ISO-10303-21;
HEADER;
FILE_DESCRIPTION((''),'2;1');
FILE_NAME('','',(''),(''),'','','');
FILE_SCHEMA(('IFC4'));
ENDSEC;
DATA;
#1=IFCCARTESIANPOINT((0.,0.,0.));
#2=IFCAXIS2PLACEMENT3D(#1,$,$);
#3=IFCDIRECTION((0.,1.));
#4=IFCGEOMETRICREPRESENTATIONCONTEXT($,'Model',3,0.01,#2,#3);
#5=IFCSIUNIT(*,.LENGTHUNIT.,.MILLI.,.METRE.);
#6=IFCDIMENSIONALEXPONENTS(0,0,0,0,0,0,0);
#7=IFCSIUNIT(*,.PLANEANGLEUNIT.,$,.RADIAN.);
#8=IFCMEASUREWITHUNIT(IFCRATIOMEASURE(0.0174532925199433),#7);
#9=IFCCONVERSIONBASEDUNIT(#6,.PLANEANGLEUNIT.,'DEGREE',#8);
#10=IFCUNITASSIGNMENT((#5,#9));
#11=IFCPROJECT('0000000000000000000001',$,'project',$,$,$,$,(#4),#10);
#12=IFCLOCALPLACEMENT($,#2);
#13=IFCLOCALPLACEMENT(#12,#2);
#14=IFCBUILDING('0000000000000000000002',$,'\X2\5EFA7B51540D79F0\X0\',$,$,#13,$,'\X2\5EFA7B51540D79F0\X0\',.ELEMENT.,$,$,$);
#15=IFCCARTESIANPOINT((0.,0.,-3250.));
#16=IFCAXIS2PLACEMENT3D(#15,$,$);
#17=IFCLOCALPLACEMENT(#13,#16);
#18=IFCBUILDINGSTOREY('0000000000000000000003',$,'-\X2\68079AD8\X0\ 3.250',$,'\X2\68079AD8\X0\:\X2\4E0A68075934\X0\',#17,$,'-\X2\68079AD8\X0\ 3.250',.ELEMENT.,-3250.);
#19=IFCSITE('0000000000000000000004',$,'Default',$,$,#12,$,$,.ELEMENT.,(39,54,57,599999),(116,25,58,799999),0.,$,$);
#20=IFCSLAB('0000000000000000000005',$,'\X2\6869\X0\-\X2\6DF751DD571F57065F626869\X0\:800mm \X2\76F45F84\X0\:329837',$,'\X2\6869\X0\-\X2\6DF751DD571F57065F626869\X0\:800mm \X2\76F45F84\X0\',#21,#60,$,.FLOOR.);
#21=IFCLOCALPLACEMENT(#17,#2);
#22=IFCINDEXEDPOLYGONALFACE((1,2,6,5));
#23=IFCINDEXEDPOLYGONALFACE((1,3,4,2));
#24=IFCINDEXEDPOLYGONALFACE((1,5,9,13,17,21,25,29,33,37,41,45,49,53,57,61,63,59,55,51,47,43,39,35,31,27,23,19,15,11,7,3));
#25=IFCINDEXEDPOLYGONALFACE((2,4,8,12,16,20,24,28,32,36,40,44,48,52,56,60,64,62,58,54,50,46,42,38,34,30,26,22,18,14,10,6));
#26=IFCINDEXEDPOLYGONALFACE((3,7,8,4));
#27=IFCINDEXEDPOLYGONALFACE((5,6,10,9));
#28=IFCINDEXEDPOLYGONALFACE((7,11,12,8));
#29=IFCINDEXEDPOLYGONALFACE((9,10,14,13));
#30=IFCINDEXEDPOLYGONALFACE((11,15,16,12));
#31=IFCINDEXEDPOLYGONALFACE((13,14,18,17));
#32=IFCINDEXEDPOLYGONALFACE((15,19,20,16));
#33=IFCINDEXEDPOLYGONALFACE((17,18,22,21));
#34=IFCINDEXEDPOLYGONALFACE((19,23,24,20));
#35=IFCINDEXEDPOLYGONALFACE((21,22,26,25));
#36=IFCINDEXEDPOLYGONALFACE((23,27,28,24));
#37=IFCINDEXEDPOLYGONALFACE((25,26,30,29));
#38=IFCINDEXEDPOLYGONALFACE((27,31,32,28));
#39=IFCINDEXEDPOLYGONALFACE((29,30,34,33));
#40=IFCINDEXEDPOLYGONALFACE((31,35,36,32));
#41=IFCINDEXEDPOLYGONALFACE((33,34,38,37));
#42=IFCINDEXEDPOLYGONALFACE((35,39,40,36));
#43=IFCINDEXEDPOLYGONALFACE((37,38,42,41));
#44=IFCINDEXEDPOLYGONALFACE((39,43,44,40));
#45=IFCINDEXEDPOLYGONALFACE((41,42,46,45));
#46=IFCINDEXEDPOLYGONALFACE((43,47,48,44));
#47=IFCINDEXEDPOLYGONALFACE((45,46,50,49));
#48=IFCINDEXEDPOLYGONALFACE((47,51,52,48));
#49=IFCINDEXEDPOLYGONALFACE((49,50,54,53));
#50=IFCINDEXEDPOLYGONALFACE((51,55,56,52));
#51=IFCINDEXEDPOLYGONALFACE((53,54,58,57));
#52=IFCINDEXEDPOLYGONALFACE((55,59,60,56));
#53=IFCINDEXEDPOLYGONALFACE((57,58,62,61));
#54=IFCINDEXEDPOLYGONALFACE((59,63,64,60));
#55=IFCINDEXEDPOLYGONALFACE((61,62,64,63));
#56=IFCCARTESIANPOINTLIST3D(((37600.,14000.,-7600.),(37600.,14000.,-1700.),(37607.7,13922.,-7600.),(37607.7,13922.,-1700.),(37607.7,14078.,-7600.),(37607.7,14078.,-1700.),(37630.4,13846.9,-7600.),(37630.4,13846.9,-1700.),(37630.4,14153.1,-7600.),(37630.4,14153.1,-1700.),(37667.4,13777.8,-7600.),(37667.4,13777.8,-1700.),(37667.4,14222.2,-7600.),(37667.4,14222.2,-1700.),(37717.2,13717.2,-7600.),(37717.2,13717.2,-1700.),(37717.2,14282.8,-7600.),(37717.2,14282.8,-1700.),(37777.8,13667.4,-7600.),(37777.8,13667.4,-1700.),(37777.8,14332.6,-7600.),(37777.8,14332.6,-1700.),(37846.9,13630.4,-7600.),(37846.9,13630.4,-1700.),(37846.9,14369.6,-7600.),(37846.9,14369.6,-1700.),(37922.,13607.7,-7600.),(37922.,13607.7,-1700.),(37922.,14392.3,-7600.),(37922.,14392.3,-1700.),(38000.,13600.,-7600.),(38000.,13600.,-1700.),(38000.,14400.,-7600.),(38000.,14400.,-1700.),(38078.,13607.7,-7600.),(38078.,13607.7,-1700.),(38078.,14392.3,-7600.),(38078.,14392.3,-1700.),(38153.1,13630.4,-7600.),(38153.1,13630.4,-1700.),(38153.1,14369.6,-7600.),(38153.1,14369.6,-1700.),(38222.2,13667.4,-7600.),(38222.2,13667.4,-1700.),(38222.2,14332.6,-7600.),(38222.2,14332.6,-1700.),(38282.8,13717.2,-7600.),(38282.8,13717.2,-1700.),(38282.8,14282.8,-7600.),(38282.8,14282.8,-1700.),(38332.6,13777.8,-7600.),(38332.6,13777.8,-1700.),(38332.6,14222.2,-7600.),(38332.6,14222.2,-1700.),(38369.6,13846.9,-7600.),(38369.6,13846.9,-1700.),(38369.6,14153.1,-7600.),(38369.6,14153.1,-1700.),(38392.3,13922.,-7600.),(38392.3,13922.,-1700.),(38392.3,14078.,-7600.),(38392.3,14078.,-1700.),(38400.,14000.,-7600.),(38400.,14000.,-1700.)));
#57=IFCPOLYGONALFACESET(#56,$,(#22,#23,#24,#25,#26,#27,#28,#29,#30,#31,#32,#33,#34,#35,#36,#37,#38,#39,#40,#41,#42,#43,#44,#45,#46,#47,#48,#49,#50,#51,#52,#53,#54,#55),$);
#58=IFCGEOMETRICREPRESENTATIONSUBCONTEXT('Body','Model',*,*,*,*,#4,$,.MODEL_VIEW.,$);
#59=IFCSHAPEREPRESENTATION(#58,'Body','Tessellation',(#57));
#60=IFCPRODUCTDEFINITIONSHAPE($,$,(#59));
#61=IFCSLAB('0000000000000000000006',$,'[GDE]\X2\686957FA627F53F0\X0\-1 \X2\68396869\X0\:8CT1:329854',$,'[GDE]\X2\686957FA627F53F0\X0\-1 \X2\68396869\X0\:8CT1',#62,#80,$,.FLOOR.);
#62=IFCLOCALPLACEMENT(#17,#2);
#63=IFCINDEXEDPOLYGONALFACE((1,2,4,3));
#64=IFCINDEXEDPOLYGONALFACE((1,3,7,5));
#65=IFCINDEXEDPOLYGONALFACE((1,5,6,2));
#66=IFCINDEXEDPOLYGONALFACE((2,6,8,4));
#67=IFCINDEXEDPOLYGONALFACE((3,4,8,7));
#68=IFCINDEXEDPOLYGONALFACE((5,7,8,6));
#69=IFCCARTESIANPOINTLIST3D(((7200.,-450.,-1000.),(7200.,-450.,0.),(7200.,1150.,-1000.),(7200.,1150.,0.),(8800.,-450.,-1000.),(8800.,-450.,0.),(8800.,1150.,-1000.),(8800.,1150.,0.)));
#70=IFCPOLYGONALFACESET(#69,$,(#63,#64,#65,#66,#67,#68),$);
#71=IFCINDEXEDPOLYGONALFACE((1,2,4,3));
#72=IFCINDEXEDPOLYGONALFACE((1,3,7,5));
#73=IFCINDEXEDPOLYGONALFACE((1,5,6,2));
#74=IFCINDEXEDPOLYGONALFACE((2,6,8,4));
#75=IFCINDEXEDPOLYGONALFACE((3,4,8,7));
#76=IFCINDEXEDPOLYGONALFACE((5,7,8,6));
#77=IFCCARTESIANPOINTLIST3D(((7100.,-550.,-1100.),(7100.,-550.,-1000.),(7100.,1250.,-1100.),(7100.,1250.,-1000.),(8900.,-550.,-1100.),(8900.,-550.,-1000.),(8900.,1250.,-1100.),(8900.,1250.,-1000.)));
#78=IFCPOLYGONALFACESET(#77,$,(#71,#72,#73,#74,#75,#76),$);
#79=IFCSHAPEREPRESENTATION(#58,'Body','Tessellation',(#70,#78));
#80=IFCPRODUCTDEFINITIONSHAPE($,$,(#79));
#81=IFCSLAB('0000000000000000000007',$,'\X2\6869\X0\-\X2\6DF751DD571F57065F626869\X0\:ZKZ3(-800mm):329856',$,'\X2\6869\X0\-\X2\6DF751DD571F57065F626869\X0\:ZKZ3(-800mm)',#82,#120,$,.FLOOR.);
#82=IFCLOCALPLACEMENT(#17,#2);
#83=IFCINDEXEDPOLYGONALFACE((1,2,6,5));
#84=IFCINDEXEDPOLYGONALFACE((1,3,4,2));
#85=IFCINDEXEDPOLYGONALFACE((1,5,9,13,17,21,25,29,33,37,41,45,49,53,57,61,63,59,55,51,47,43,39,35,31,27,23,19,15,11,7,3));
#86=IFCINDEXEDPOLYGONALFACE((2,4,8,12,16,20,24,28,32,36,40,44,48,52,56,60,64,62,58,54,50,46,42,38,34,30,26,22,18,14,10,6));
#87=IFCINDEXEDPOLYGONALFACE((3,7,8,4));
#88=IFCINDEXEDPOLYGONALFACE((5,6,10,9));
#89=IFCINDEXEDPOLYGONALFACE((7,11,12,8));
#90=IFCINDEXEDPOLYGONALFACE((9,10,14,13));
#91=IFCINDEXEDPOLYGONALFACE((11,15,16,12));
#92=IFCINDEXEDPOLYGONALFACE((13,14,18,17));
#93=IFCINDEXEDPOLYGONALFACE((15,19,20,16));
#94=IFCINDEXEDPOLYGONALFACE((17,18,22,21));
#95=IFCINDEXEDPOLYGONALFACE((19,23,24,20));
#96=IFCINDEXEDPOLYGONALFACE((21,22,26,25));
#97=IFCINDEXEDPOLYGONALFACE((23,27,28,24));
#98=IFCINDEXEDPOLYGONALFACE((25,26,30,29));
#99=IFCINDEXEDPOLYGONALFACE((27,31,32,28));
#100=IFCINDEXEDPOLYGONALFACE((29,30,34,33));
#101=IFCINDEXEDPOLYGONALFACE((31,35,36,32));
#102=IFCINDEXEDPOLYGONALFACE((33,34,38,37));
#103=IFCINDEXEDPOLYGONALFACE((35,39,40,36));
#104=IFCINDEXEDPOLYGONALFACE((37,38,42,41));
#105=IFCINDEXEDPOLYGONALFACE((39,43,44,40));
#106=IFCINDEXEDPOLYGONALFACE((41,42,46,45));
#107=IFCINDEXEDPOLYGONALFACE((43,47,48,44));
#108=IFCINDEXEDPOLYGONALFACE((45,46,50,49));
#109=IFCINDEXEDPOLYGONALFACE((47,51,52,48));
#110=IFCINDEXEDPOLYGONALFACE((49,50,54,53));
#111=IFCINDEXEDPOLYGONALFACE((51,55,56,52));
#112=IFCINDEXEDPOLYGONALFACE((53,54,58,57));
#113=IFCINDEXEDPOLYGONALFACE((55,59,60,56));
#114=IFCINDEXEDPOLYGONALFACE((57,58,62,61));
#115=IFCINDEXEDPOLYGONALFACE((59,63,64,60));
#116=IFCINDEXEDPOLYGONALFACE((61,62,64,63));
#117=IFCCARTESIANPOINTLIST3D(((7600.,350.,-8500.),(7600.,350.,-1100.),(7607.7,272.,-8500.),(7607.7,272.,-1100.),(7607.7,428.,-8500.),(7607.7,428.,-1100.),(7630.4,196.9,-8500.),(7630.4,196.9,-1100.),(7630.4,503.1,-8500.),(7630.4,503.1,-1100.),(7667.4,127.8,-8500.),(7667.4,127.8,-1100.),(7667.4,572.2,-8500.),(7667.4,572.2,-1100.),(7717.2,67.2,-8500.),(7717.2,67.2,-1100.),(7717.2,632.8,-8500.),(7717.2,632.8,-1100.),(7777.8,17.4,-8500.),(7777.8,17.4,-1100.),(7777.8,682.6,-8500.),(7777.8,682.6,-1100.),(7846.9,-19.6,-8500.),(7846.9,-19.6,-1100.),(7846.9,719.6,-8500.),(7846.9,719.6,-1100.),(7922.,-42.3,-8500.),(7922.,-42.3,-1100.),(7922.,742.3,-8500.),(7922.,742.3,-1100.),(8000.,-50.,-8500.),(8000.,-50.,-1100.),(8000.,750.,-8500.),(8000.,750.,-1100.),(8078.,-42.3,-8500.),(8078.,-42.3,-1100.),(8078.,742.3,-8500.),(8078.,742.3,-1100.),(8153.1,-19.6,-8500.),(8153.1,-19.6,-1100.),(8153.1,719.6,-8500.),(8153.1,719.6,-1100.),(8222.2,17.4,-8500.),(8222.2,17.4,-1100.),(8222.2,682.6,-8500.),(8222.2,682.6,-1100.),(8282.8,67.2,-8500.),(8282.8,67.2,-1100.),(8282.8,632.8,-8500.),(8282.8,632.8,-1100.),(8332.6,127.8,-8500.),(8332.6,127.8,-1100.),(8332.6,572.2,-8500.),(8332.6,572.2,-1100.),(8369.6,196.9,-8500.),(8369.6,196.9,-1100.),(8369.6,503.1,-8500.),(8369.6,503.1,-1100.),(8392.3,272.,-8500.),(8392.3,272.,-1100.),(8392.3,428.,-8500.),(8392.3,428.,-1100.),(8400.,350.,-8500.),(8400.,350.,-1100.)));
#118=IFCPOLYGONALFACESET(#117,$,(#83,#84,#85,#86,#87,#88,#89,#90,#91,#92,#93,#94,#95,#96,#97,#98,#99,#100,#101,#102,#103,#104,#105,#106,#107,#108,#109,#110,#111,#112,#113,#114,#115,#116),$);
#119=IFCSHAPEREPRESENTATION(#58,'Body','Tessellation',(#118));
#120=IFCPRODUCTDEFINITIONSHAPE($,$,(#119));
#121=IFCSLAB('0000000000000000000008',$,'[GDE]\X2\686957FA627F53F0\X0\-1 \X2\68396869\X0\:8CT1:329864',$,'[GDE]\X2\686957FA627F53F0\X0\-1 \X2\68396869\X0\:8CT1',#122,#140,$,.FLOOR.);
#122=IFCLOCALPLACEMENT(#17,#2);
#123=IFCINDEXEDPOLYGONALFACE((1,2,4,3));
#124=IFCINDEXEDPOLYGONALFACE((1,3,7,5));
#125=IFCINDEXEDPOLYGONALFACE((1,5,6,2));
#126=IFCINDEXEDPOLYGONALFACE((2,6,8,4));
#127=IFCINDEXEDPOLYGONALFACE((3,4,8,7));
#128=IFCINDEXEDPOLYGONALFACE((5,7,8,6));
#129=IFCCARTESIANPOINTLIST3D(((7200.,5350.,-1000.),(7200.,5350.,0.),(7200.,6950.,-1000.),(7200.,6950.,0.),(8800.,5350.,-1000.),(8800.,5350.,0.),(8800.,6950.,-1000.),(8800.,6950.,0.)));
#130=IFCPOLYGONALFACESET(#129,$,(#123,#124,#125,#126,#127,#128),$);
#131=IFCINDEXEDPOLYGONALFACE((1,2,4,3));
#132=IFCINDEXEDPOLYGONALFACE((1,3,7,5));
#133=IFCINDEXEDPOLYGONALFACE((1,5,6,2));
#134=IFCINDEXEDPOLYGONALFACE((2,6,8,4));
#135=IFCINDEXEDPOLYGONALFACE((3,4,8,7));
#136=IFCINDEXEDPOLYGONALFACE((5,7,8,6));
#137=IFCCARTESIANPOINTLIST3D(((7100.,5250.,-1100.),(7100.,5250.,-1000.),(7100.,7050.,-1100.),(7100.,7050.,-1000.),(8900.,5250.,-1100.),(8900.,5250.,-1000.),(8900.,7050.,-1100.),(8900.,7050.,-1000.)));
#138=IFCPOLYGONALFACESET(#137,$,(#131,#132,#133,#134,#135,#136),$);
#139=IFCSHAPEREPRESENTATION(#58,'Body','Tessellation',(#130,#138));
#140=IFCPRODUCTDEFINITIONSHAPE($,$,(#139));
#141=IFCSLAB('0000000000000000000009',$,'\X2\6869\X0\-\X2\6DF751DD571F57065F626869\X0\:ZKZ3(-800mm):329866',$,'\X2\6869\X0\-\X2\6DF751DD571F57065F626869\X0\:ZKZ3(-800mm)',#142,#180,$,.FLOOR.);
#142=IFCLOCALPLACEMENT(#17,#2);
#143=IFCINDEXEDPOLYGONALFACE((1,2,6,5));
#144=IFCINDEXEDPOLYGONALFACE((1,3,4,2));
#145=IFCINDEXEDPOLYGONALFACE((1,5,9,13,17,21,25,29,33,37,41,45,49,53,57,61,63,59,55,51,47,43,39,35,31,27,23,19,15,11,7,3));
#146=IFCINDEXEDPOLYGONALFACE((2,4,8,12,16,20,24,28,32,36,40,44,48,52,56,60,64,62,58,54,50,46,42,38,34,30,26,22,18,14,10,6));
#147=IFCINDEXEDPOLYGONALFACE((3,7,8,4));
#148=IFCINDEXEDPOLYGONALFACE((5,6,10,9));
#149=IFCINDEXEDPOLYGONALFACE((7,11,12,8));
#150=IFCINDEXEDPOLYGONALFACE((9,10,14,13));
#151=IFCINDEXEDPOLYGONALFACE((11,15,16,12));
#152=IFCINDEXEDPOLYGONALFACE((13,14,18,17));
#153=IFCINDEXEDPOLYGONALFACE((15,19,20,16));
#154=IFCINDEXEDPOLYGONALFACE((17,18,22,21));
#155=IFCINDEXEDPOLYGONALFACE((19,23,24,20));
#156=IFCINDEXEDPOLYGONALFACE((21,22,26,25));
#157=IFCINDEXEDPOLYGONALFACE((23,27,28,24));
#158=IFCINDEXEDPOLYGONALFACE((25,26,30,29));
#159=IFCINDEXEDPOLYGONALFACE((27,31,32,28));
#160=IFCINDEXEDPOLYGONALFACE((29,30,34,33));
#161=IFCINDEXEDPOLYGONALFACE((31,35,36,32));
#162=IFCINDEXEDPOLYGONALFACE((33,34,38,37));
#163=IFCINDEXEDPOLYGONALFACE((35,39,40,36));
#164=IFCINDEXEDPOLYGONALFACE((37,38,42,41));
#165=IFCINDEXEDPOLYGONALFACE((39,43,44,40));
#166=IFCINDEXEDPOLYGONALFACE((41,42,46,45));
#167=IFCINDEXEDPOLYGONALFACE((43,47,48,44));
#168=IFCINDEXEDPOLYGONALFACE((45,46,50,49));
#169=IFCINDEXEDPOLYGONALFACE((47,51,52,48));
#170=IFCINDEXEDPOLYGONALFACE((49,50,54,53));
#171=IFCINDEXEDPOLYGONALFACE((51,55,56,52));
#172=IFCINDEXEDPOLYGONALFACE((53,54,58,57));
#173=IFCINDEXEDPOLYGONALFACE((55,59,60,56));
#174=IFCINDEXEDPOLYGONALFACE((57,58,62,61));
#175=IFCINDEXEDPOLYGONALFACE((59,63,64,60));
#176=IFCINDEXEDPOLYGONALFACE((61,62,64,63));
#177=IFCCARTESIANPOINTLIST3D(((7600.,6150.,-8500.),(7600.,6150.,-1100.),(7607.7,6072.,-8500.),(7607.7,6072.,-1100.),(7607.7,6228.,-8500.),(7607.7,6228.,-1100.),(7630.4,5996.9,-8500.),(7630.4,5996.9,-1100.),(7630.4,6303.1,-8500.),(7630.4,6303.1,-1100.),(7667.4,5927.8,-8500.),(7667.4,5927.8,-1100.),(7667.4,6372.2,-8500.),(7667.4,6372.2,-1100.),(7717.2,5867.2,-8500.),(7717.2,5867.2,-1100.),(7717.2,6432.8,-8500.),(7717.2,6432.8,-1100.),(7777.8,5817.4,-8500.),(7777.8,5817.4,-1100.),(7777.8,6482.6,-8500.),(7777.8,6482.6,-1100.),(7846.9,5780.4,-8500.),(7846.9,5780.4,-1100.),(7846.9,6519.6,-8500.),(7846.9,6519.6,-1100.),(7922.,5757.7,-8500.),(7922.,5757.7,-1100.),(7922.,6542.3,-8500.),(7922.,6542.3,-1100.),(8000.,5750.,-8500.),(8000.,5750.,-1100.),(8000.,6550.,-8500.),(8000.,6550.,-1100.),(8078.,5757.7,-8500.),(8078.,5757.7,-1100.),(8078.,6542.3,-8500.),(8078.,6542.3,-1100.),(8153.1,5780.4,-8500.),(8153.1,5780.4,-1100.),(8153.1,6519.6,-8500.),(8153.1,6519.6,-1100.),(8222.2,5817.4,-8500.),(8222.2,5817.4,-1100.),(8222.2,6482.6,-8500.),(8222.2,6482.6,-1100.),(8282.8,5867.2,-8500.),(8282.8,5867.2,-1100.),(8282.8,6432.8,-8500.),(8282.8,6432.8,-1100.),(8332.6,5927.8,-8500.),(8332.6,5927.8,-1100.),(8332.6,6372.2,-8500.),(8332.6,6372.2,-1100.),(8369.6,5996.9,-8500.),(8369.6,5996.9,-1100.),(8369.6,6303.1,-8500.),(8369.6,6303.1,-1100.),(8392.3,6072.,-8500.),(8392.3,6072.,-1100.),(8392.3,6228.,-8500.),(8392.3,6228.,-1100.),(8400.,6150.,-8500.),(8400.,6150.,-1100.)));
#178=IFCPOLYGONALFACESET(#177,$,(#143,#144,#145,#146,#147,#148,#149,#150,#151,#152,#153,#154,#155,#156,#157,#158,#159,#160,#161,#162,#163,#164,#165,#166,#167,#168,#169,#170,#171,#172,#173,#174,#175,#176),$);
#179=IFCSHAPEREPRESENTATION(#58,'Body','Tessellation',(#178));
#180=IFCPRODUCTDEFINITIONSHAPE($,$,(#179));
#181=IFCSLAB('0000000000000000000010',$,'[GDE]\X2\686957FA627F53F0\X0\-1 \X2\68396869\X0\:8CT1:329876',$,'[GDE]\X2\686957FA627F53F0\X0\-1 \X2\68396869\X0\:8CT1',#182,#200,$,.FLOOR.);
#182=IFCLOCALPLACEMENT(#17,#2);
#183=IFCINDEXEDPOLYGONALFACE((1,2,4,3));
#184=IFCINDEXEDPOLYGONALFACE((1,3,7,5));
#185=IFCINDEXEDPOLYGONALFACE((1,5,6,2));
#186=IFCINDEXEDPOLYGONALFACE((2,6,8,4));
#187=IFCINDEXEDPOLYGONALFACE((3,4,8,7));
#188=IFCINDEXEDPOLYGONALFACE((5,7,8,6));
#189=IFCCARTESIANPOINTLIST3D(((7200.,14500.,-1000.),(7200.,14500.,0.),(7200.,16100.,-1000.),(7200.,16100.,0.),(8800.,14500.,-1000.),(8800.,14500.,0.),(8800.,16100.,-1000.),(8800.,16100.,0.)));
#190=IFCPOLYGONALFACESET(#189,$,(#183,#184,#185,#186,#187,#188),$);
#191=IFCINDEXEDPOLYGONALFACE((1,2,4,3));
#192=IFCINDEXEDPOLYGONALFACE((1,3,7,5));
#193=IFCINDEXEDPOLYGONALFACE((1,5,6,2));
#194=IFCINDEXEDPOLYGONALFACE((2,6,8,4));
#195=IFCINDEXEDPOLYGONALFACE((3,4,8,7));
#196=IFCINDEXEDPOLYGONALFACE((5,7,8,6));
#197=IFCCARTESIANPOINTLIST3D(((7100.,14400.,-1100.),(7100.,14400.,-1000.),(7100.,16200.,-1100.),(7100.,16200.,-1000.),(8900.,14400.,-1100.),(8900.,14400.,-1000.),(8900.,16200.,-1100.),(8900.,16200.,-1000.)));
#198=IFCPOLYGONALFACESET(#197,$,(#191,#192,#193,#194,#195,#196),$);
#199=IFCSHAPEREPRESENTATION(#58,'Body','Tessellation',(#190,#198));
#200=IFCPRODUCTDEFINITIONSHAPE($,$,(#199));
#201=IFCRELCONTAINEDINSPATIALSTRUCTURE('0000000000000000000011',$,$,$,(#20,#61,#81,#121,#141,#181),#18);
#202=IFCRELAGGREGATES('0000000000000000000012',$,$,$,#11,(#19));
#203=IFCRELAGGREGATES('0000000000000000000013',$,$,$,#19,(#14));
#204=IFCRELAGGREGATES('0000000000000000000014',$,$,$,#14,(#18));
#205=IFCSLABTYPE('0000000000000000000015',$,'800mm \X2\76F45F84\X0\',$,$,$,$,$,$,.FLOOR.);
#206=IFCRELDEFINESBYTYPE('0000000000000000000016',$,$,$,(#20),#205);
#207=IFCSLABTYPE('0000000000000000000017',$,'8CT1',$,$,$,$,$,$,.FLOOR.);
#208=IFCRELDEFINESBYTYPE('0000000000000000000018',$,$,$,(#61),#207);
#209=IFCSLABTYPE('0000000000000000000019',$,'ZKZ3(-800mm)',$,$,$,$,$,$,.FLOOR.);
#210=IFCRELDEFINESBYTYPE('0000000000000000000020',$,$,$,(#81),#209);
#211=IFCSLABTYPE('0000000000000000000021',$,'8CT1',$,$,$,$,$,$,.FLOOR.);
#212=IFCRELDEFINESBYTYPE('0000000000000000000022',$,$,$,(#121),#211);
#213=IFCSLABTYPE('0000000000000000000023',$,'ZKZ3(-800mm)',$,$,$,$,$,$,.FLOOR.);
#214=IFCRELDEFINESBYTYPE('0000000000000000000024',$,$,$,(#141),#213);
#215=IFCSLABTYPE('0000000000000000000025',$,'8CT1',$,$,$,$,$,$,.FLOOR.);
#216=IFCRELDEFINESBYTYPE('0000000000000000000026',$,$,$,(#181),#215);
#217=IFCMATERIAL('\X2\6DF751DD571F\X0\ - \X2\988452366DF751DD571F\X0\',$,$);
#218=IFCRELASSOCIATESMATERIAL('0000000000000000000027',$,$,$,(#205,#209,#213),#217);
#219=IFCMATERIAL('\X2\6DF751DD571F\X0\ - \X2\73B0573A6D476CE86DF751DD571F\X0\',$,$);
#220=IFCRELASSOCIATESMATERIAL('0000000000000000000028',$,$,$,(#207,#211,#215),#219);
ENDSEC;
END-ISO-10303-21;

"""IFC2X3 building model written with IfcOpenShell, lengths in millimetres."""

from ifc_helpers import new_model, entity, si_unit, converted_unit, direction, frame, frame_2d, origin, origin_2d_with_axis, place, context, subcontext, project, spatial, rectangle, circle, extrude, material, type_object, element, save


model = new_model("IFC2X3")

# Units and contexts
model_context = context("Model", 3, precision=0.01, world=origin(), true_north=direction((0.0, 1.0)))
body_context = subcontext(model_context, "Body", "Model", "MODEL_VIEW")
ifc_project = project(units=[si_unit("LENGTHUNIT", "METRE", prefix="MILLI"), converted_unit("PLANEANGLEUNIT", "DEGREE", entity("IfcRatioMeasure", 0.0174532925199433), si_unit("PLANEANGLEUNIT", "RADIAN"), dimensions=[0, 0, 0, 0, 0, 0, 0])], contexts=[model_context])

# Site, building, storey
site_placement = place(None, origin())
site = spatial("IfcSite", under=ifc_project, at=site_placement, Name="Default", CompositionType="ELEMENT", RefLatitude=(39, 54, 57, 599999), RefLongitude=(116, 25, 58, 799999), RefElevation=0.0)
building_placement = place(site_placement, origin())
building = spatial("IfcBuilding", under=site, at=building_placement, Name="建筑名称", LongName="建筑名称", CompositionType="ELEMENT")
storey_placement = place(building_placement, frame((0.0, 0.0, -3250.0)))
storey = spatial("IfcBuildingStorey", under=building, at=storey_placement, Name="-标高 3.250", ObjectType="标高:上标头", LongName="-标高 3.250", CompositionType="ELEMENT", Elevation=-3250.0)

# Slabs
ifc_material_1 = material(Name="混凝土 - 现场浇注混凝土")
ifc_material_2 = material(Name="混凝土 - 预制混凝土")
slab_type_1 = type_object("IfcSlabType", Name="800mm 直径", PredefinedType="FLOOR", material=ifc_material_2)
slab_1_placement = place(storey_placement, origin())
element("IfcSlab", 1, at=slab_1_placement, inside=storey, type_object=slab_type_1, Name="桩-混凝土圆形桩:800mm 直径:329837", ObjectType="桩-混凝土圆形桩:800mm 直径", PredefinedType="FLOOR", context=body_context, shape_type="SweptSolid", body=[
    extrude(circle(Radius=400.0, at=origin_2d_with_axis()), frame((38000.0, 14000.0, -7600.0), z_axis=(0.0, 0.0, 1.0), x_axis=(0.0, -1.0, 0.0)), (0.0, 0.0, 1.0), 5900.0),
])
slab_type_2 = type_object("IfcSlabType", Name="8CT1", PredefinedType="FLOOR", material=ifc_material_1)
slab_2_placement = place(storey_placement, origin())
element("IfcSlab", 2, at=slab_2_placement, inside=storey, type_object=slab_type_2, Name="[GDE]桩基承台-1 根桩:8CT1:329854", ObjectType="[GDE]桩基承台-1 根桩:8CT1", PredefinedType="FLOOR", context=body_context, shape_type="SweptSolid", body=[
    extrude(rectangle(XDim=1600.0, YDim=1600.0, at=origin_2d_with_axis()), frame((8000.0, 350.0, -1000.0), z_axis=(0.0, 0.0, 1.0), x_axis=(-1.0, 0.0, 0.0)), (0.0, 0.0, 1.0), 1000.0),
    extrude(rectangle(XDim=1800.0, YDim=1800.0, at=origin_2d_with_axis()), frame((8000.0, 350.0, -1100.0), z_axis=(0.0, 0.0, 1.0), x_axis=(-1.0, 0.0, 0.0)), (0.0, 0.0, 1.0), 100.0),
])
slab_type_3 = type_object("IfcSlabType", Name="ZKZ3(-800mm)", PredefinedType="FLOOR", material=ifc_material_2)
slab_3_placement = place(storey_placement, origin())
element("IfcSlab", 3, at=slab_3_placement, inside=storey, type_object=slab_type_3, Name="桩-混凝土圆形桩:ZKZ3(-800mm):329856", ObjectType="桩-混凝土圆形桩:ZKZ3(-800mm)", PredefinedType="FLOOR", context=body_context, shape_type="SweptSolid", body=[
    extrude(circle(Radius=400.0, at=frame_2d((0.0, 0.0), x_axis=(1.0, 0.0))), frame((8000.0, 350.0, -8500.0)), (0.0, 0.0, 1.0), 7400.0),
])
slab_type_4 = type_object("IfcSlabType", Name="8CT1", PredefinedType="FLOOR", material=ifc_material_1)
slab_4_placement = place(storey_placement, origin())
element("IfcSlab", 4, at=slab_4_placement, inside=storey, type_object=slab_type_4, Name="[GDE]桩基承台-1 根桩:8CT1:329864", ObjectType="[GDE]桩基承台-1 根桩:8CT1", PredefinedType="FLOOR", context=body_context, shape_type="SweptSolid", body=[
    extrude(rectangle(XDim=1600.0, YDim=1600.0, at=origin_2d_with_axis()), frame((8000.0, 6150.0, -1000.0), z_axis=(0.0, 0.0, 1.0), x_axis=(-1.0, 0.0, 0.0)), (0.0, 0.0, 1.0), 1000.0),
    extrude(rectangle(XDim=1800.0, YDim=1800.0, at=origin_2d_with_axis()), frame((8000.0, 6150.0, -1100.0), z_axis=(0.0, 0.0, 1.0), x_axis=(-1.0, 0.0, 0.0)), (0.0, 0.0, 1.0), 100.0),
])
slab_type_5 = type_object("IfcSlabType", Name="ZKZ3(-800mm)", PredefinedType="FLOOR", material=ifc_material_2)
slab_5_placement = place(storey_placement, origin())
element("IfcSlab", 5, at=slab_5_placement, inside=storey, type_object=slab_type_5, Name="桩-混凝土圆形桩:ZKZ3(-800mm):329866", ObjectType="桩-混凝土圆形桩:ZKZ3(-800mm)", PredefinedType="FLOOR", context=body_context, shape_type="SweptSolid", body=[
    extrude(circle(Radius=400.0, at=origin_2d_with_axis()), frame((8000.0, 6150.0, -8500.0)), (0.0, 0.0, 1.0), 7400.0),
])
slab_type_6 = type_object("IfcSlabType", Name="8CT1", PredefinedType="FLOOR", material=ifc_material_1)
slab_6_placement = place(storey_placement, origin())
element("IfcSlab", 6, at=slab_6_placement, inside=storey, type_object=slab_type_6, Name="[GDE]桩基承台-1 根桩:8CT1:329876", ObjectType="[GDE]桩基承台-1 根桩:8CT1", PredefinedType="FLOOR", context=body_context, shape_type="SweptSolid", body=[
    extrude(rectangle(XDim=1600.0, YDim=1600.0, at=origin_2d_with_axis()), frame((8000.0, 15300.0, -1000.0), z_axis=(0.0, 0.0, 1.0), x_axis=(-1.0, 0.0, 0.0)), (0.0, 0.0, 1.0), 1000.0),
    extrude(rectangle(XDim=1800.0, YDim=1800.0, at=frame_2d((0.0, 0.0), x_axis=(1.0, 0.0))), frame((8000.0, 15300.0, -1100.0), z_axis=(0.0, 0.0, 1.0), x_axis=(-1.0, 0.0, 0.0)), (0.0, 0.0, 1.0), 100.0),
])

save(model, "model.ifc")
